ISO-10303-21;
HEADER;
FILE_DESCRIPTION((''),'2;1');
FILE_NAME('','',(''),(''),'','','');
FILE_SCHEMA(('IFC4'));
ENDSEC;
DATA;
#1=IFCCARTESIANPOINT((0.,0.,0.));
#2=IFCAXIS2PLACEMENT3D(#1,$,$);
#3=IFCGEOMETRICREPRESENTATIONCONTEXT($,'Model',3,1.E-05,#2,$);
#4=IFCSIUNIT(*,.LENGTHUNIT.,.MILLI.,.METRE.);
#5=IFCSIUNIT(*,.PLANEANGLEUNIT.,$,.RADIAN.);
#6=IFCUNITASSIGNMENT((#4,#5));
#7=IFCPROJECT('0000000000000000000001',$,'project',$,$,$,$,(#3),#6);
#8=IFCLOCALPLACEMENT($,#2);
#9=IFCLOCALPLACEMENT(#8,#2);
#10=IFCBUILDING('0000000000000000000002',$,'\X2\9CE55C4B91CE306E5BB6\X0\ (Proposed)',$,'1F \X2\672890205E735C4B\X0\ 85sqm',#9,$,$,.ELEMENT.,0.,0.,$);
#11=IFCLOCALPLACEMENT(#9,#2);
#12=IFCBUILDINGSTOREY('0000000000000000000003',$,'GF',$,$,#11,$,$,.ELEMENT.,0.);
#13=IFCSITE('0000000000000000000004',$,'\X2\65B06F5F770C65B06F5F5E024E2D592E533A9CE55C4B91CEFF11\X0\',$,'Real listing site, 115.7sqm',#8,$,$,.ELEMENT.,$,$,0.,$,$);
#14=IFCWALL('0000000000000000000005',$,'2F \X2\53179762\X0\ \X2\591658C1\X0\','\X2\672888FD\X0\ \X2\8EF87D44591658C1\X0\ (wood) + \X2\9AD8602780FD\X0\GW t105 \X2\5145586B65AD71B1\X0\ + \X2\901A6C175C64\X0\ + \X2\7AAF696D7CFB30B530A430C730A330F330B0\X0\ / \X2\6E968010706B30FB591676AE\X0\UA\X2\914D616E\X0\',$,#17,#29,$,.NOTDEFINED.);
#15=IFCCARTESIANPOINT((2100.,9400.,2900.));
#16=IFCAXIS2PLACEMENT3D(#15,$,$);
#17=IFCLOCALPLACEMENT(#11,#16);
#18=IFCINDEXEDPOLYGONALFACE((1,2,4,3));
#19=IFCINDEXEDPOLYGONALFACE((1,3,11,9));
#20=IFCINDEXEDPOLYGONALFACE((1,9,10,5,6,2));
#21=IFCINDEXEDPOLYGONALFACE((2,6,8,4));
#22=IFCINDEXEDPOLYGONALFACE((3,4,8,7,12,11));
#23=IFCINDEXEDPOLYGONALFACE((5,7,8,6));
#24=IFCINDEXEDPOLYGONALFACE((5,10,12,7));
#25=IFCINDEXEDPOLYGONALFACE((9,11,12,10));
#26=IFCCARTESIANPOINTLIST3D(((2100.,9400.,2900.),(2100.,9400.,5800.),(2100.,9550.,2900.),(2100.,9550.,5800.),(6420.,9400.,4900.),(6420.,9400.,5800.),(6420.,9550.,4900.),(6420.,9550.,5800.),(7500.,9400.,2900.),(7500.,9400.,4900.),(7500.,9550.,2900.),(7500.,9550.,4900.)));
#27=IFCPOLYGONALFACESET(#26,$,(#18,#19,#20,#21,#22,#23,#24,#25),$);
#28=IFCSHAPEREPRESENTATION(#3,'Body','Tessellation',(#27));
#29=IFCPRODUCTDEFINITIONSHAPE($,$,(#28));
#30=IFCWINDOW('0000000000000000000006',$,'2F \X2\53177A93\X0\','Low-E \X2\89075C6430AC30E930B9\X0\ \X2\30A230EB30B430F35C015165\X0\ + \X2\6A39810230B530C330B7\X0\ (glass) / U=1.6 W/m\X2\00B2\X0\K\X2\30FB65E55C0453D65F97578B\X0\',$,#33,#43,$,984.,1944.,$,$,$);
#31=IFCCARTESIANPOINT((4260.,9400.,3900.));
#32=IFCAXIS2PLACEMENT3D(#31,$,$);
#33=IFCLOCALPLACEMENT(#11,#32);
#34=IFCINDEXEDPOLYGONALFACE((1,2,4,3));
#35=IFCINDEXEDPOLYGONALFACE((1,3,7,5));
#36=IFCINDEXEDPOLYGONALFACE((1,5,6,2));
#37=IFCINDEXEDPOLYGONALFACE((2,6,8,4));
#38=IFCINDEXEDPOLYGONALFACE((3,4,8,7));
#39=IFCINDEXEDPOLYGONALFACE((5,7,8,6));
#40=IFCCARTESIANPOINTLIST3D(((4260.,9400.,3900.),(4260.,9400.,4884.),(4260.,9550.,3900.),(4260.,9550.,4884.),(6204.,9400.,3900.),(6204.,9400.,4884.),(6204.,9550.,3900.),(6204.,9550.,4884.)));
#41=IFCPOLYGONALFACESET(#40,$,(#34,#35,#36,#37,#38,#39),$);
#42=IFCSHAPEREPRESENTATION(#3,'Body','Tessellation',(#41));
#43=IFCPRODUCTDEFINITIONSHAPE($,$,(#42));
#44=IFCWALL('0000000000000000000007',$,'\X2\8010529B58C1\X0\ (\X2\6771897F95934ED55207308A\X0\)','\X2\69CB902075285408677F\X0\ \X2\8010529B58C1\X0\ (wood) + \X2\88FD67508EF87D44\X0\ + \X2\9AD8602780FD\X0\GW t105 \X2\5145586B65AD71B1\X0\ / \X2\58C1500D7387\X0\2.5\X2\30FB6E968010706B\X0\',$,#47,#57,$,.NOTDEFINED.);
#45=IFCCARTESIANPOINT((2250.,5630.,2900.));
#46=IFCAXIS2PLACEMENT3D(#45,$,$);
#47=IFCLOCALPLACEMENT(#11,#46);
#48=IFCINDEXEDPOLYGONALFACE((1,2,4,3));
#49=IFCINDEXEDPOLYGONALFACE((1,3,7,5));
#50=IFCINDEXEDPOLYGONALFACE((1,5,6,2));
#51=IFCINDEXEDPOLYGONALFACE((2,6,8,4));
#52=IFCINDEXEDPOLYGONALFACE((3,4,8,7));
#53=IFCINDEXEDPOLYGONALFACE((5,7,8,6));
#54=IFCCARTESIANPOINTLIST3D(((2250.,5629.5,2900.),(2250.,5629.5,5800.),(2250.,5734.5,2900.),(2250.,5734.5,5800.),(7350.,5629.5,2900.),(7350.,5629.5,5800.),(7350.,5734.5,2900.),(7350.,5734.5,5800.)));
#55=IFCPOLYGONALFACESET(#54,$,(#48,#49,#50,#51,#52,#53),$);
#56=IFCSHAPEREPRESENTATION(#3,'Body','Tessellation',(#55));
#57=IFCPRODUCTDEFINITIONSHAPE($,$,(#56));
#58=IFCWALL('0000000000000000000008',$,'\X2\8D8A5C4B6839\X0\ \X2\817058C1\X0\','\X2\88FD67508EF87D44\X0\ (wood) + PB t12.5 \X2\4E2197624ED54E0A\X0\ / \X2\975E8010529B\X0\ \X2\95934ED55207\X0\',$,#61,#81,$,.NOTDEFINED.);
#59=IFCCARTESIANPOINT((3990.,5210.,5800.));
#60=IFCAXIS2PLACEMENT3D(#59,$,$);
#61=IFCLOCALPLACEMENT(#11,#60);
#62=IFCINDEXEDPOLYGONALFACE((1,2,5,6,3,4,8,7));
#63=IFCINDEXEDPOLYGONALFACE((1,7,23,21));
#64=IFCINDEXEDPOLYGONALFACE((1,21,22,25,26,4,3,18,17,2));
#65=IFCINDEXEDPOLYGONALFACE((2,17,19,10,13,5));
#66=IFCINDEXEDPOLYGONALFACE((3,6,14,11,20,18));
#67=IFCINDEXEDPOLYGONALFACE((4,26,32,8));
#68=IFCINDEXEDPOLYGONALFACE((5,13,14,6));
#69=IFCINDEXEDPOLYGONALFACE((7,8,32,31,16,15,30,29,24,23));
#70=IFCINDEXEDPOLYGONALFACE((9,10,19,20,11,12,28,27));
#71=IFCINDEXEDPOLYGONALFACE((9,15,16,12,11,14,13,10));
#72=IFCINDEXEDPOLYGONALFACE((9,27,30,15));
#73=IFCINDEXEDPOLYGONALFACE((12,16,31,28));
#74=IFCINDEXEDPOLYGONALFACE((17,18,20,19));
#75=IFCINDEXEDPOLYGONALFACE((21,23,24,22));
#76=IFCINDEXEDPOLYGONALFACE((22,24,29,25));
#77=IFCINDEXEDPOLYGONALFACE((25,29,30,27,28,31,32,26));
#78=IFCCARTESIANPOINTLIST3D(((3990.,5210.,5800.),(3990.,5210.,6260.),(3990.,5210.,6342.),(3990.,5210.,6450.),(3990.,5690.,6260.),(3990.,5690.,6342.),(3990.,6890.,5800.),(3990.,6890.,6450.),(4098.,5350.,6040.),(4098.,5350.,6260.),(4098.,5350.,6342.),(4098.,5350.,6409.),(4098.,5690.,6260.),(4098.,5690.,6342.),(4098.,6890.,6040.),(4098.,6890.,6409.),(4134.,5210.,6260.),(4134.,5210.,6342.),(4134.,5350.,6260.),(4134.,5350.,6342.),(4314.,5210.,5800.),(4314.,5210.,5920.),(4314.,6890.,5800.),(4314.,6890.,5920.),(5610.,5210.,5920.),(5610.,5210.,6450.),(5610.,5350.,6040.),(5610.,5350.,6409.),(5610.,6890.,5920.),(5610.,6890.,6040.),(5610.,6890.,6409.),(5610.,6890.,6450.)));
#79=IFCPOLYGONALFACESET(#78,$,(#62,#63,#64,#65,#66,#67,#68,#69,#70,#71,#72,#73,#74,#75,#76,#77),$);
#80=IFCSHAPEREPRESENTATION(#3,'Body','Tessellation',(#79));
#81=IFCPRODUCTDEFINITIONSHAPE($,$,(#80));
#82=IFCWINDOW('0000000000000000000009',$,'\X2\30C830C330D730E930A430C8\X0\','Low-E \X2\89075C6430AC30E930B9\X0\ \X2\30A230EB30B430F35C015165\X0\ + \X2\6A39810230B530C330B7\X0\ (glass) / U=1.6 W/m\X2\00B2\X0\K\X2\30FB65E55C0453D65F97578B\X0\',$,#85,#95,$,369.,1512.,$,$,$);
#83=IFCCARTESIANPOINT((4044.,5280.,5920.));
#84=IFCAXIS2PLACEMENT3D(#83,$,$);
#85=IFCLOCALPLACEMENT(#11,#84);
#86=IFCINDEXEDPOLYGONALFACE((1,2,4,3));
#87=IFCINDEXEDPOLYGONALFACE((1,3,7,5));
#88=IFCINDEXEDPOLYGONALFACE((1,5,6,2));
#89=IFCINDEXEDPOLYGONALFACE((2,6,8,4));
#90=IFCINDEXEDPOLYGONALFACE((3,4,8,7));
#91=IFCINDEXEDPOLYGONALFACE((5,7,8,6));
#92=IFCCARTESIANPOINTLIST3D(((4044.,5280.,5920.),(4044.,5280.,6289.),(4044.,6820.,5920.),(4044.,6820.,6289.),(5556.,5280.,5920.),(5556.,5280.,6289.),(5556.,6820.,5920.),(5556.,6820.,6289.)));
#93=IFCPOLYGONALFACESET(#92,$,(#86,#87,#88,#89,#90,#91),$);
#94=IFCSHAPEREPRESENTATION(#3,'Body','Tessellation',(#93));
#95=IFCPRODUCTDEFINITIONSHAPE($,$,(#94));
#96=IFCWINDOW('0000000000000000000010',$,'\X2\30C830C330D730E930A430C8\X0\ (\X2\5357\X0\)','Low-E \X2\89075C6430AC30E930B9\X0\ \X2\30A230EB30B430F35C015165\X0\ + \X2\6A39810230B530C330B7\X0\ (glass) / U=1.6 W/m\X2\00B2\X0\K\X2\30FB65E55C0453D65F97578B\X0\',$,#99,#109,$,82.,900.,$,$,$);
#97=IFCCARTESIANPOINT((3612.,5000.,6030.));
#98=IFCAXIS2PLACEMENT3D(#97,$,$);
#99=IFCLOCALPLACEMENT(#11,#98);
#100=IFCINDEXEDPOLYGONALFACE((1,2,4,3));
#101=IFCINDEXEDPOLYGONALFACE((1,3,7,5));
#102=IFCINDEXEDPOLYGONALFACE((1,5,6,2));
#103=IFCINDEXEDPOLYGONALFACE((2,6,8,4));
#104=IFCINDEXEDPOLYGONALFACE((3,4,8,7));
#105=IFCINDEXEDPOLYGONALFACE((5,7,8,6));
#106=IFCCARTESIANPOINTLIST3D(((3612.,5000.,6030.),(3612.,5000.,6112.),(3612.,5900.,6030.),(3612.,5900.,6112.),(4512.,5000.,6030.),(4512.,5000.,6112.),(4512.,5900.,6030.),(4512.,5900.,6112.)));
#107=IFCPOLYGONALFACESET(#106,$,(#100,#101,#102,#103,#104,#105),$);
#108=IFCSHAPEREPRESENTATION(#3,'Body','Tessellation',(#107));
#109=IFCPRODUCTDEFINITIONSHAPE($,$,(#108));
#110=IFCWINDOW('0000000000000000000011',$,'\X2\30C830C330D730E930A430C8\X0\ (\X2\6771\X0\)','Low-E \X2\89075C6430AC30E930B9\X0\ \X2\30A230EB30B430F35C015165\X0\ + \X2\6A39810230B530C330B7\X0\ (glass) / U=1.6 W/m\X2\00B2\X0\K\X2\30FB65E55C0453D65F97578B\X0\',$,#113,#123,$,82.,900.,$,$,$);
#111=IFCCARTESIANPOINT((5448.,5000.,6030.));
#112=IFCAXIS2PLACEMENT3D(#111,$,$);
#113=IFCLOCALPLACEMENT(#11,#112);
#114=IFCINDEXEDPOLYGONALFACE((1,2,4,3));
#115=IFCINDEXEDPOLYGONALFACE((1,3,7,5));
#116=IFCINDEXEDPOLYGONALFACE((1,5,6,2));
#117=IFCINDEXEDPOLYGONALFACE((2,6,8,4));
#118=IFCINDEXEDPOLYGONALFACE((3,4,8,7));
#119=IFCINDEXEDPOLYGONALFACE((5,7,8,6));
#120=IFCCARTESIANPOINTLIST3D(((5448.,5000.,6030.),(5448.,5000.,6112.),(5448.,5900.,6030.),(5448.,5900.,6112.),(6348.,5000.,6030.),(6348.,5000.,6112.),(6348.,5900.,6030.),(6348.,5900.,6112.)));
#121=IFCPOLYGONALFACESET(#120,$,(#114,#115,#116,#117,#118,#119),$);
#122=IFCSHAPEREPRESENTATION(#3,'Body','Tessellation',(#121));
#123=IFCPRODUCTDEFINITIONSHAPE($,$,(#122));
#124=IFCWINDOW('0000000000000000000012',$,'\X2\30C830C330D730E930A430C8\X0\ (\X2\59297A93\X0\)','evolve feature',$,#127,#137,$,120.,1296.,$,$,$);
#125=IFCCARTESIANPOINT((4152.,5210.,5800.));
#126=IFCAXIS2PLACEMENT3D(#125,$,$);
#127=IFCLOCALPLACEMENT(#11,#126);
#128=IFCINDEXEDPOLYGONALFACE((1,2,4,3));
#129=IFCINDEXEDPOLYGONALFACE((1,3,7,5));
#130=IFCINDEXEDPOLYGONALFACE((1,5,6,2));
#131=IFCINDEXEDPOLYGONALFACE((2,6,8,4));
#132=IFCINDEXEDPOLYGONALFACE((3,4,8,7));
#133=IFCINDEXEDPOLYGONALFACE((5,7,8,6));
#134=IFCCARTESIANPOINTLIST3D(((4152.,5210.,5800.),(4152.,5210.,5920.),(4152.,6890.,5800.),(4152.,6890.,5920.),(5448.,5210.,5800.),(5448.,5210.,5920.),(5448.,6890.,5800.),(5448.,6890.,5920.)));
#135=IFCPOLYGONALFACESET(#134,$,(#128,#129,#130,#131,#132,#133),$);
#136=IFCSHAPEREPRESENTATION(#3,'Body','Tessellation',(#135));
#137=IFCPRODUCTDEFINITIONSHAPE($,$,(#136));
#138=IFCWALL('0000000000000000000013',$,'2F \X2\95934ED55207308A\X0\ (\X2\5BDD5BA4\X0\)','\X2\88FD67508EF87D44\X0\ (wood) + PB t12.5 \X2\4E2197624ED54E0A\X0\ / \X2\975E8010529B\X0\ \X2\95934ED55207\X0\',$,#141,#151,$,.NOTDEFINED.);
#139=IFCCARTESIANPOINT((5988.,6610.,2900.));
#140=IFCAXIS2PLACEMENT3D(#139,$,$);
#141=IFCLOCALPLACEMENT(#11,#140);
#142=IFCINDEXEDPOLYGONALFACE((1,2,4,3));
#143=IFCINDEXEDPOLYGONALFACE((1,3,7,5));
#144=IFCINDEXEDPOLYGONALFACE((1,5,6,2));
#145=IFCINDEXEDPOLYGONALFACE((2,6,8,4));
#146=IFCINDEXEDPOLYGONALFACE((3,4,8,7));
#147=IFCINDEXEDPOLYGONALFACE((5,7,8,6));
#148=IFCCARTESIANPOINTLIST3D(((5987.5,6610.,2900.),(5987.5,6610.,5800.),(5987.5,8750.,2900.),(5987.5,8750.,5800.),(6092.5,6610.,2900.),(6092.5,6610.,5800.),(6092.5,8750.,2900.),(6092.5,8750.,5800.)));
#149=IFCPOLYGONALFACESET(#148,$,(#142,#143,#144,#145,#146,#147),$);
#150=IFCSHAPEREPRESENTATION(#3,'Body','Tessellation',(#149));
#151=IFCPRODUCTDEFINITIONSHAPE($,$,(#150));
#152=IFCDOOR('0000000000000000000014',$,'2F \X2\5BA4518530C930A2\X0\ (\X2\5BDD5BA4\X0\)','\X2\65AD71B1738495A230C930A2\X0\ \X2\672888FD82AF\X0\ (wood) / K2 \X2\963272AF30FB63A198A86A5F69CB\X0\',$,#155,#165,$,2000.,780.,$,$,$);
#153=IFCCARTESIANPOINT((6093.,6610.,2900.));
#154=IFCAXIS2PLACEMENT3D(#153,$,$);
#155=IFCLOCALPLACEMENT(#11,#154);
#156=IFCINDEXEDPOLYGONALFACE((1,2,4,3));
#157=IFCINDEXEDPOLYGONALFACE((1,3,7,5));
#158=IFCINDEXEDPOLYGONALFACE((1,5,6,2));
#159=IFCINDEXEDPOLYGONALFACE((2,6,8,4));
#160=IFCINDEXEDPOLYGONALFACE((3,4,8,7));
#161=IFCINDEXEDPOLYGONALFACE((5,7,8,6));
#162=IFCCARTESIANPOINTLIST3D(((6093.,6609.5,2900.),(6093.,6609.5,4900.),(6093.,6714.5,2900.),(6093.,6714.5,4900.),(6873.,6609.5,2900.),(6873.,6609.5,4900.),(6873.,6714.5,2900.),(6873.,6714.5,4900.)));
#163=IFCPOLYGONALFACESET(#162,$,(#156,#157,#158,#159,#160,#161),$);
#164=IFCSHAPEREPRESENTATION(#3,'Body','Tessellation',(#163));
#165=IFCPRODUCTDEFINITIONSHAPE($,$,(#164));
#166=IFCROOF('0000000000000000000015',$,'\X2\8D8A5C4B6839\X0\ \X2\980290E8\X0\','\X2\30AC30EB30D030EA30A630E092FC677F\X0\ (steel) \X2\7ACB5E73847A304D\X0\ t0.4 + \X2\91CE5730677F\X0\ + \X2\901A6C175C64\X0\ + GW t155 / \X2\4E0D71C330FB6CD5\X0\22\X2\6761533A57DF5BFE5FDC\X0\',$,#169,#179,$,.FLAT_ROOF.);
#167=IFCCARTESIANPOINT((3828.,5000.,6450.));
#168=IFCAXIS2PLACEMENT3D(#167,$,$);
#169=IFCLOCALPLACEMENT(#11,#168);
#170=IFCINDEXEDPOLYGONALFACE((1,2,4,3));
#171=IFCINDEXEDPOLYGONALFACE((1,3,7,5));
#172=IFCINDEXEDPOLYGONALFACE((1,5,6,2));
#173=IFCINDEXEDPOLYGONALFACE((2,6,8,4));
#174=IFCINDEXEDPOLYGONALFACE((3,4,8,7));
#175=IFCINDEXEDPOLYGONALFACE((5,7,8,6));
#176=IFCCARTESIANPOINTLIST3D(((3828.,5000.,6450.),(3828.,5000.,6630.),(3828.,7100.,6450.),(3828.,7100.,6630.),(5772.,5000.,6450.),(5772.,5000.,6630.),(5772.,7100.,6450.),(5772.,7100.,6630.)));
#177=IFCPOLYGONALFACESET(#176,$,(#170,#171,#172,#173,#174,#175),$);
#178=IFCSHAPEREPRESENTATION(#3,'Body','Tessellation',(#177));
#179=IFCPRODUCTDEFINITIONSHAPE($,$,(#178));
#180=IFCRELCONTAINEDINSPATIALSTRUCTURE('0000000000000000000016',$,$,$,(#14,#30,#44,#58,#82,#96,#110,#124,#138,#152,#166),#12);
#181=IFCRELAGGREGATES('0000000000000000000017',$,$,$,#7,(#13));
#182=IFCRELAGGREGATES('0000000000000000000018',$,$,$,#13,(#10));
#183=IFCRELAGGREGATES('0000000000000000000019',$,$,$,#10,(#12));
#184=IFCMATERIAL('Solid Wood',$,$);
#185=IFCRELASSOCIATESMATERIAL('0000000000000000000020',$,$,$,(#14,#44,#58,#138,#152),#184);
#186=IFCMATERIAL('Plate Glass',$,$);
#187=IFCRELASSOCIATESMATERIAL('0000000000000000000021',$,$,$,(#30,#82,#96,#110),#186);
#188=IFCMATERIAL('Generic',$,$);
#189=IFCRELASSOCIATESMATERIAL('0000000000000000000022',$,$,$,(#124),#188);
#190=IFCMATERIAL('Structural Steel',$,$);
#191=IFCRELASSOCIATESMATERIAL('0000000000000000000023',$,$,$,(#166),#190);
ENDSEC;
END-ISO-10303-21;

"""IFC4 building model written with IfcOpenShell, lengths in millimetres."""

from ifc_helpers import new_model, si_unit, frame, frame_2d, origin, place, context, project, spatial, rectangle, extrude, material, element, fill, save


model = new_model("IFC4")

# Units and contexts
model_context = context("Model", 3, precision=1e-05, world=origin())
ifc_project = project(units=[si_unit("LENGTHUNIT", "METRE", prefix="MILLI"), si_unit("PLANEANGLEUNIT", "RADIAN")], contexts=[model_context])

# Site, building, storey
site_placement = place(None, origin())
site = spatial("IfcSite", under=ifc_project, at=site_placement, Name="新潟県新潟市中央区鳥屋野１", ObjectType="Real listing site, 115.7sqm", CompositionType="ELEMENT", RefElevation=0.0)
building_placement = place(site_placement, origin())
building = spatial("IfcBuilding", under=site, at=building_placement, Name="鳥屋野の家 (Proposed)", ObjectType="1F 木造平屋 85sqm", CompositionType="ELEMENT", ElevationOfRefHeight=0.0, ElevationOfTerrain=0.0)
storey_placement = place(building_placement, origin())
storey = spatial("IfcBuildingStorey", under=building, at=storey_placement, Name="GF", CompositionType="ELEMENT", Elevation=0.0)

# Wall, opening, window
ifc_material_1 = material(Name="Solid Wood")
wall_1_placement = place(storey_placement, frame((2100.0, 9400.0, 2900.0)))
wall_1 = element("IfcWall", 1, at=wall_1_placement, inside=storey, material=ifc_material_1, Name="2F 北面 外壁", Description="木製 軸組外壁 (wood) + 高性能GW t105 充填断熱 + 通気層 + 窯業系サイディング / 準耐火・外皮UA配慮", PredefinedType="NOTDEFINED", context=model_context, shape_type="SweptSolid", body=[
    extrude(rectangle(XDim=5400.0, YDim=150.0, at=frame_2d((2700.0, 75.0))), frame((2100.0, 9400.0, 2900.0)), (0.0, 0.0, 1.0), 2900.0),
])
opening_1_placement = place(storey_placement, frame((4260.0, 9400.0, 3900.0)))
opening_1 = element("IfcOpeningElement", 2, at=opening_1_placement, cuts=wall_1, PredefinedType="NOTDEFINED", context=model_context, shape_type="SweptSolid", body=[
    extrude(rectangle(XDim=1944.0, YDim=150.0, at=frame_2d((972.0, 75.0))), frame((4260.0, 9400.0, 3900.0)), (0.0, 0.0, 1.0), 984.0),
])
ifc_material_2 = material(Name="Plate Glass")
window_1_placement = place(storey_placement, frame((4260.0, 9400.0, 3900.0)))
window_1 = element("IfcWindow", 3, at=window_1_placement, inside=storey, material=ifc_material_2, Name="2F 北窓", Description="Low-E 複層ガラス アルゴン封入 + 樹脂サッシ (glass) / U=1.6 W/m²K・日射取得型", OverallHeight=984.0, OverallWidth=1944.0, context=model_context, shape_type="SweptSolid", body=[
    extrude(rectangle(XDim=1944.0, YDim=150.0, at=frame_2d((972.0, 75.0))), frame((4260.0, 9400.0, 3900.0)), (0.0, 0.0, 1.0), 984.0),
])
fill(opening_1, window_1)

# Wall
wall_2_placement = place(storey_placement, frame((2250.0, 5630.0, 2900.0)))
element("IfcWall", 4, at=wall_2_placement, inside=storey, material=ifc_material_1, Name="耐力壁 (東西間仕切り)", Description="構造用合板 耐力壁 (wood) + 製材軸組 + 高性能GW t105 充填断熱 / 壁倍率2.5・準耐火", PredefinedType="NOTDEFINED", context=model_context, shape_type="SweptSolid", body=[
    extrude(rectangle(XDim=5100.0, YDim=105.0, at=frame_2d((2550.0, 52.0))), frame((2250.0, 5630.0, 2900.0)), (0.0, 0.0, 1.0), 2900.0),
])

# Wall, openings, windows
wall_3_placement = place(storey_placement, frame((3990.0, 5210.0, 5800.0)))
wall_3 = element("IfcWall", 5, at=wall_3_placement, inside=storey, material=ifc_material_1, Name="越屋根 腰壁", Description="製材軸組 (wood) + PB t12.5 両面仕上 / 非耐力 間仕切", PredefinedType="NOTDEFINED", context=model_context, shape_type="SweptSolid", body=[
    extrude(rectangle(XDim=1620.0, YDim=1680.0, at=frame_2d((810.0, 840.0))), frame((3990.0, 5210.0, 5800.0)), (0.0, 0.0, 1.0), 650.0),
])
opening_2_placement = place(storey_placement, frame((4044.0, 5280.0, 5920.0)))
opening_2 = element("IfcOpeningElement", 6, at=opening_2_placement, cuts=wall_3, PredefinedType="NOTDEFINED", context=model_context, shape_type="SweptSolid", body=[
    extrude(rectangle(XDim=1512.0, YDim=1540.0, at=frame_2d((756.0, 770.0))), frame((4044.0, 5280.0, 5920.0)), (0.0, 0.0, 1.0), 369.0),
])
opening_3_placement = place(storey_placement, frame((3612.0, 5000.0, 6030.0)))
opening_3 = element("IfcOpeningElement", 7, at=opening_3_placement, cuts=wall_3, PredefinedType="NOTDEFINED", context=model_context, shape_type="SweptSolid", body=[
    extrude(rectangle(XDim=900.0, YDim=900.0, at=frame_2d((450.0, 450.0))), frame((3612.0, 5000.0, 6030.0)), (0.0, 0.0, 1.0), 82.0),
])
opening_4_placement = place(storey_placement, frame((5448.0, 5000.0, 6030.0)))
opening_4 = element("IfcOpeningElement", 8, at=opening_4_placement, cuts=wall_3, PredefinedType="NOTDEFINED", context=model_context, shape_type="SweptSolid", body=[
    extrude(rectangle(XDim=900.0, YDim=900.0, at=frame_2d((450.0, 450.0))), frame((5448.0, 5000.0, 6030.0)), (0.0, 0.0, 1.0), 82.0),
])
opening_5_placement = place(storey_placement, frame((4152.0, 5210.0, 5800.0)))
opening_5 = element("IfcOpeningElement", 9, at=opening_5_placement, cuts=wall_3, PredefinedType="NOTDEFINED", context=model_context, shape_type="SweptSolid", body=[
    extrude(rectangle(XDim=1296.0, YDim=1680.0, at=frame_2d((648.0, 840.0))), frame((4152.0, 5210.0, 5800.0)), (0.0, 0.0, 1.0), 120.0),
])
window_2_placement = place(storey_placement, frame((4044.0, 5280.0, 5920.0)))
window_2 = element("IfcWindow", 10, at=window_2_placement, inside=storey, material=ifc_material_2, Name="トップライト", Description="Low-E 複層ガラス アルゴン封入 + 樹脂サッシ (glass) / U=1.6 W/m²K・日射取得型", OverallHeight=369.0, OverallWidth=1512.0, context=model_context, shape_type="SweptSolid", body=[
    extrude(rectangle(XDim=1512.0, YDim=1540.0, at=frame_2d((756.0, 770.0))), frame((4044.0, 5280.0, 5920.0)), (0.0, 0.0, 1.0), 369.0),
])
fill(opening_2, window_2)
window_3_placement = place(storey_placement, frame((3612.0, 5000.0, 6030.0)))
window_3 = element("IfcWindow", 11, at=window_3_placement, inside=storey, material=ifc_material_2, Name="トップライト (南)", Description="Low-E 複層ガラス アルゴン封入 + 樹脂サッシ (glass) / U=1.6 W/m²K・日射取得型", OverallHeight=82.0, OverallWidth=900.0, context=model_context, shape_type="SweptSolid", body=[
    extrude(rectangle(XDim=900.0, YDim=900.0, at=frame_2d((450.0, 450.0))), frame((3612.0, 5000.0, 6030.0)), (0.0, 0.0, 1.0), 82.0),
])
fill(opening_3, window_3)
window_4_placement = place(storey_placement, frame((5448.0, 5000.0, 6030.0)))
window_4 = element("IfcWindow", 12, at=window_4_placement, inside=storey, material=ifc_material_2, Name="トップライト (東)", Description="Low-E 複層ガラス アルゴン封入 + 樹脂サッシ (glass) / U=1.6 W/m²K・日射取得型", OverallHeight=82.0, OverallWidth=900.0, context=model_context, shape_type="SweptSolid", body=[
    extrude(rectangle(XDim=900.0, YDim=900.0, at=frame_2d((450.0, 450.0))), frame((5448.0, 5000.0, 6030.0)), (0.0, 0.0, 1.0), 82.0),
])
fill(opening_4, window_4)
ifc_material_3 = material(Name="Generic")
window_5_placement = place(storey_placement, frame((4152.0, 5210.0, 5800.0)))
window_5 = element("IfcWindow", 13, at=window_5_placement, inside=storey, material=ifc_material_3, Name="トップライト (天窓)", Description="evolve feature", OverallHeight=120.0, OverallWidth=1296.0, context=model_context, shape_type="SweptSolid", body=[
    extrude(rectangle(XDim=1296.0, YDim=1680.0, at=frame_2d((648.0, 840.0))), frame((4152.0, 5210.0, 5800.0)), (0.0, 0.0, 1.0), 120.0),
])
fill(opening_5, window_5)

# Wall
wall_4_placement = place(storey_placement, frame((5988.0, 6610.0, 2900.0)))
element("IfcWall", 14, at=wall_4_placement, inside=storey, material=ifc_material_1, Name="2F 間仕切り (寝室)", Description="製材軸組 (wood) + PB t12.5 両面仕上 / 非耐力 間仕切", PredefinedType="NOTDEFINED", context=model_context, shape_type="SweptSolid", body=[
    extrude(rectangle(XDim=105.0, YDim=2140.0, at=frame_2d((52.0, 1070.0))), frame((5988.0, 6610.0, 2900.0)), (0.0, 0.0, 1.0), 2900.0),
])

# Door
door_placement = place(storey_placement, frame((6093.0, 6610.0, 2900.0)))
element("IfcDoor", 15, at=door_placement, inside=storey, material=ifc_material_1, Name="2F 室内ドア (寝室)", Description="断熱玄関ドア 木製芯 (wood) / K2 防犯・採風機構", OverallHeight=2000.0, OverallWidth=780.0, context=model_context, shape_type="SweptSolid", body=[
    extrude(rectangle(XDim=780.0, YDim=105.0, at=frame_2d((390.0, 52.0))), frame((6093.0, 6610.0, 2900.0)), (0.0, 0.0, 1.0), 2000.0),
])

# Roof
ifc_material_4 = material(Name="Structural Steel")
roof_placement = place(storey_placement, frame((3828.0, 5000.0, 6450.0)))
element("IfcRoof", 16, at=roof_placement, inside=storey, material=ifc_material_4, Name="越屋根 頂部", Description="ガルバリウム鋼板 (steel) 立平葺き t0.4 + 野地板 + 通気層 + GW t155 / 不燃・法22条区域対応", PredefinedType="FLAT_ROOF", context=model_context, shape_type="SweptSolid", body=[
    extrude(rectangle(XDim=1944.0, YDim=2100.0, at=frame_2d((972.0, 1050.0))), frame((3828.0, 5000.0, 6450.0)), (0.0, 0.0, 1.0), 180.0),
])

save(model, "model.ifc")
